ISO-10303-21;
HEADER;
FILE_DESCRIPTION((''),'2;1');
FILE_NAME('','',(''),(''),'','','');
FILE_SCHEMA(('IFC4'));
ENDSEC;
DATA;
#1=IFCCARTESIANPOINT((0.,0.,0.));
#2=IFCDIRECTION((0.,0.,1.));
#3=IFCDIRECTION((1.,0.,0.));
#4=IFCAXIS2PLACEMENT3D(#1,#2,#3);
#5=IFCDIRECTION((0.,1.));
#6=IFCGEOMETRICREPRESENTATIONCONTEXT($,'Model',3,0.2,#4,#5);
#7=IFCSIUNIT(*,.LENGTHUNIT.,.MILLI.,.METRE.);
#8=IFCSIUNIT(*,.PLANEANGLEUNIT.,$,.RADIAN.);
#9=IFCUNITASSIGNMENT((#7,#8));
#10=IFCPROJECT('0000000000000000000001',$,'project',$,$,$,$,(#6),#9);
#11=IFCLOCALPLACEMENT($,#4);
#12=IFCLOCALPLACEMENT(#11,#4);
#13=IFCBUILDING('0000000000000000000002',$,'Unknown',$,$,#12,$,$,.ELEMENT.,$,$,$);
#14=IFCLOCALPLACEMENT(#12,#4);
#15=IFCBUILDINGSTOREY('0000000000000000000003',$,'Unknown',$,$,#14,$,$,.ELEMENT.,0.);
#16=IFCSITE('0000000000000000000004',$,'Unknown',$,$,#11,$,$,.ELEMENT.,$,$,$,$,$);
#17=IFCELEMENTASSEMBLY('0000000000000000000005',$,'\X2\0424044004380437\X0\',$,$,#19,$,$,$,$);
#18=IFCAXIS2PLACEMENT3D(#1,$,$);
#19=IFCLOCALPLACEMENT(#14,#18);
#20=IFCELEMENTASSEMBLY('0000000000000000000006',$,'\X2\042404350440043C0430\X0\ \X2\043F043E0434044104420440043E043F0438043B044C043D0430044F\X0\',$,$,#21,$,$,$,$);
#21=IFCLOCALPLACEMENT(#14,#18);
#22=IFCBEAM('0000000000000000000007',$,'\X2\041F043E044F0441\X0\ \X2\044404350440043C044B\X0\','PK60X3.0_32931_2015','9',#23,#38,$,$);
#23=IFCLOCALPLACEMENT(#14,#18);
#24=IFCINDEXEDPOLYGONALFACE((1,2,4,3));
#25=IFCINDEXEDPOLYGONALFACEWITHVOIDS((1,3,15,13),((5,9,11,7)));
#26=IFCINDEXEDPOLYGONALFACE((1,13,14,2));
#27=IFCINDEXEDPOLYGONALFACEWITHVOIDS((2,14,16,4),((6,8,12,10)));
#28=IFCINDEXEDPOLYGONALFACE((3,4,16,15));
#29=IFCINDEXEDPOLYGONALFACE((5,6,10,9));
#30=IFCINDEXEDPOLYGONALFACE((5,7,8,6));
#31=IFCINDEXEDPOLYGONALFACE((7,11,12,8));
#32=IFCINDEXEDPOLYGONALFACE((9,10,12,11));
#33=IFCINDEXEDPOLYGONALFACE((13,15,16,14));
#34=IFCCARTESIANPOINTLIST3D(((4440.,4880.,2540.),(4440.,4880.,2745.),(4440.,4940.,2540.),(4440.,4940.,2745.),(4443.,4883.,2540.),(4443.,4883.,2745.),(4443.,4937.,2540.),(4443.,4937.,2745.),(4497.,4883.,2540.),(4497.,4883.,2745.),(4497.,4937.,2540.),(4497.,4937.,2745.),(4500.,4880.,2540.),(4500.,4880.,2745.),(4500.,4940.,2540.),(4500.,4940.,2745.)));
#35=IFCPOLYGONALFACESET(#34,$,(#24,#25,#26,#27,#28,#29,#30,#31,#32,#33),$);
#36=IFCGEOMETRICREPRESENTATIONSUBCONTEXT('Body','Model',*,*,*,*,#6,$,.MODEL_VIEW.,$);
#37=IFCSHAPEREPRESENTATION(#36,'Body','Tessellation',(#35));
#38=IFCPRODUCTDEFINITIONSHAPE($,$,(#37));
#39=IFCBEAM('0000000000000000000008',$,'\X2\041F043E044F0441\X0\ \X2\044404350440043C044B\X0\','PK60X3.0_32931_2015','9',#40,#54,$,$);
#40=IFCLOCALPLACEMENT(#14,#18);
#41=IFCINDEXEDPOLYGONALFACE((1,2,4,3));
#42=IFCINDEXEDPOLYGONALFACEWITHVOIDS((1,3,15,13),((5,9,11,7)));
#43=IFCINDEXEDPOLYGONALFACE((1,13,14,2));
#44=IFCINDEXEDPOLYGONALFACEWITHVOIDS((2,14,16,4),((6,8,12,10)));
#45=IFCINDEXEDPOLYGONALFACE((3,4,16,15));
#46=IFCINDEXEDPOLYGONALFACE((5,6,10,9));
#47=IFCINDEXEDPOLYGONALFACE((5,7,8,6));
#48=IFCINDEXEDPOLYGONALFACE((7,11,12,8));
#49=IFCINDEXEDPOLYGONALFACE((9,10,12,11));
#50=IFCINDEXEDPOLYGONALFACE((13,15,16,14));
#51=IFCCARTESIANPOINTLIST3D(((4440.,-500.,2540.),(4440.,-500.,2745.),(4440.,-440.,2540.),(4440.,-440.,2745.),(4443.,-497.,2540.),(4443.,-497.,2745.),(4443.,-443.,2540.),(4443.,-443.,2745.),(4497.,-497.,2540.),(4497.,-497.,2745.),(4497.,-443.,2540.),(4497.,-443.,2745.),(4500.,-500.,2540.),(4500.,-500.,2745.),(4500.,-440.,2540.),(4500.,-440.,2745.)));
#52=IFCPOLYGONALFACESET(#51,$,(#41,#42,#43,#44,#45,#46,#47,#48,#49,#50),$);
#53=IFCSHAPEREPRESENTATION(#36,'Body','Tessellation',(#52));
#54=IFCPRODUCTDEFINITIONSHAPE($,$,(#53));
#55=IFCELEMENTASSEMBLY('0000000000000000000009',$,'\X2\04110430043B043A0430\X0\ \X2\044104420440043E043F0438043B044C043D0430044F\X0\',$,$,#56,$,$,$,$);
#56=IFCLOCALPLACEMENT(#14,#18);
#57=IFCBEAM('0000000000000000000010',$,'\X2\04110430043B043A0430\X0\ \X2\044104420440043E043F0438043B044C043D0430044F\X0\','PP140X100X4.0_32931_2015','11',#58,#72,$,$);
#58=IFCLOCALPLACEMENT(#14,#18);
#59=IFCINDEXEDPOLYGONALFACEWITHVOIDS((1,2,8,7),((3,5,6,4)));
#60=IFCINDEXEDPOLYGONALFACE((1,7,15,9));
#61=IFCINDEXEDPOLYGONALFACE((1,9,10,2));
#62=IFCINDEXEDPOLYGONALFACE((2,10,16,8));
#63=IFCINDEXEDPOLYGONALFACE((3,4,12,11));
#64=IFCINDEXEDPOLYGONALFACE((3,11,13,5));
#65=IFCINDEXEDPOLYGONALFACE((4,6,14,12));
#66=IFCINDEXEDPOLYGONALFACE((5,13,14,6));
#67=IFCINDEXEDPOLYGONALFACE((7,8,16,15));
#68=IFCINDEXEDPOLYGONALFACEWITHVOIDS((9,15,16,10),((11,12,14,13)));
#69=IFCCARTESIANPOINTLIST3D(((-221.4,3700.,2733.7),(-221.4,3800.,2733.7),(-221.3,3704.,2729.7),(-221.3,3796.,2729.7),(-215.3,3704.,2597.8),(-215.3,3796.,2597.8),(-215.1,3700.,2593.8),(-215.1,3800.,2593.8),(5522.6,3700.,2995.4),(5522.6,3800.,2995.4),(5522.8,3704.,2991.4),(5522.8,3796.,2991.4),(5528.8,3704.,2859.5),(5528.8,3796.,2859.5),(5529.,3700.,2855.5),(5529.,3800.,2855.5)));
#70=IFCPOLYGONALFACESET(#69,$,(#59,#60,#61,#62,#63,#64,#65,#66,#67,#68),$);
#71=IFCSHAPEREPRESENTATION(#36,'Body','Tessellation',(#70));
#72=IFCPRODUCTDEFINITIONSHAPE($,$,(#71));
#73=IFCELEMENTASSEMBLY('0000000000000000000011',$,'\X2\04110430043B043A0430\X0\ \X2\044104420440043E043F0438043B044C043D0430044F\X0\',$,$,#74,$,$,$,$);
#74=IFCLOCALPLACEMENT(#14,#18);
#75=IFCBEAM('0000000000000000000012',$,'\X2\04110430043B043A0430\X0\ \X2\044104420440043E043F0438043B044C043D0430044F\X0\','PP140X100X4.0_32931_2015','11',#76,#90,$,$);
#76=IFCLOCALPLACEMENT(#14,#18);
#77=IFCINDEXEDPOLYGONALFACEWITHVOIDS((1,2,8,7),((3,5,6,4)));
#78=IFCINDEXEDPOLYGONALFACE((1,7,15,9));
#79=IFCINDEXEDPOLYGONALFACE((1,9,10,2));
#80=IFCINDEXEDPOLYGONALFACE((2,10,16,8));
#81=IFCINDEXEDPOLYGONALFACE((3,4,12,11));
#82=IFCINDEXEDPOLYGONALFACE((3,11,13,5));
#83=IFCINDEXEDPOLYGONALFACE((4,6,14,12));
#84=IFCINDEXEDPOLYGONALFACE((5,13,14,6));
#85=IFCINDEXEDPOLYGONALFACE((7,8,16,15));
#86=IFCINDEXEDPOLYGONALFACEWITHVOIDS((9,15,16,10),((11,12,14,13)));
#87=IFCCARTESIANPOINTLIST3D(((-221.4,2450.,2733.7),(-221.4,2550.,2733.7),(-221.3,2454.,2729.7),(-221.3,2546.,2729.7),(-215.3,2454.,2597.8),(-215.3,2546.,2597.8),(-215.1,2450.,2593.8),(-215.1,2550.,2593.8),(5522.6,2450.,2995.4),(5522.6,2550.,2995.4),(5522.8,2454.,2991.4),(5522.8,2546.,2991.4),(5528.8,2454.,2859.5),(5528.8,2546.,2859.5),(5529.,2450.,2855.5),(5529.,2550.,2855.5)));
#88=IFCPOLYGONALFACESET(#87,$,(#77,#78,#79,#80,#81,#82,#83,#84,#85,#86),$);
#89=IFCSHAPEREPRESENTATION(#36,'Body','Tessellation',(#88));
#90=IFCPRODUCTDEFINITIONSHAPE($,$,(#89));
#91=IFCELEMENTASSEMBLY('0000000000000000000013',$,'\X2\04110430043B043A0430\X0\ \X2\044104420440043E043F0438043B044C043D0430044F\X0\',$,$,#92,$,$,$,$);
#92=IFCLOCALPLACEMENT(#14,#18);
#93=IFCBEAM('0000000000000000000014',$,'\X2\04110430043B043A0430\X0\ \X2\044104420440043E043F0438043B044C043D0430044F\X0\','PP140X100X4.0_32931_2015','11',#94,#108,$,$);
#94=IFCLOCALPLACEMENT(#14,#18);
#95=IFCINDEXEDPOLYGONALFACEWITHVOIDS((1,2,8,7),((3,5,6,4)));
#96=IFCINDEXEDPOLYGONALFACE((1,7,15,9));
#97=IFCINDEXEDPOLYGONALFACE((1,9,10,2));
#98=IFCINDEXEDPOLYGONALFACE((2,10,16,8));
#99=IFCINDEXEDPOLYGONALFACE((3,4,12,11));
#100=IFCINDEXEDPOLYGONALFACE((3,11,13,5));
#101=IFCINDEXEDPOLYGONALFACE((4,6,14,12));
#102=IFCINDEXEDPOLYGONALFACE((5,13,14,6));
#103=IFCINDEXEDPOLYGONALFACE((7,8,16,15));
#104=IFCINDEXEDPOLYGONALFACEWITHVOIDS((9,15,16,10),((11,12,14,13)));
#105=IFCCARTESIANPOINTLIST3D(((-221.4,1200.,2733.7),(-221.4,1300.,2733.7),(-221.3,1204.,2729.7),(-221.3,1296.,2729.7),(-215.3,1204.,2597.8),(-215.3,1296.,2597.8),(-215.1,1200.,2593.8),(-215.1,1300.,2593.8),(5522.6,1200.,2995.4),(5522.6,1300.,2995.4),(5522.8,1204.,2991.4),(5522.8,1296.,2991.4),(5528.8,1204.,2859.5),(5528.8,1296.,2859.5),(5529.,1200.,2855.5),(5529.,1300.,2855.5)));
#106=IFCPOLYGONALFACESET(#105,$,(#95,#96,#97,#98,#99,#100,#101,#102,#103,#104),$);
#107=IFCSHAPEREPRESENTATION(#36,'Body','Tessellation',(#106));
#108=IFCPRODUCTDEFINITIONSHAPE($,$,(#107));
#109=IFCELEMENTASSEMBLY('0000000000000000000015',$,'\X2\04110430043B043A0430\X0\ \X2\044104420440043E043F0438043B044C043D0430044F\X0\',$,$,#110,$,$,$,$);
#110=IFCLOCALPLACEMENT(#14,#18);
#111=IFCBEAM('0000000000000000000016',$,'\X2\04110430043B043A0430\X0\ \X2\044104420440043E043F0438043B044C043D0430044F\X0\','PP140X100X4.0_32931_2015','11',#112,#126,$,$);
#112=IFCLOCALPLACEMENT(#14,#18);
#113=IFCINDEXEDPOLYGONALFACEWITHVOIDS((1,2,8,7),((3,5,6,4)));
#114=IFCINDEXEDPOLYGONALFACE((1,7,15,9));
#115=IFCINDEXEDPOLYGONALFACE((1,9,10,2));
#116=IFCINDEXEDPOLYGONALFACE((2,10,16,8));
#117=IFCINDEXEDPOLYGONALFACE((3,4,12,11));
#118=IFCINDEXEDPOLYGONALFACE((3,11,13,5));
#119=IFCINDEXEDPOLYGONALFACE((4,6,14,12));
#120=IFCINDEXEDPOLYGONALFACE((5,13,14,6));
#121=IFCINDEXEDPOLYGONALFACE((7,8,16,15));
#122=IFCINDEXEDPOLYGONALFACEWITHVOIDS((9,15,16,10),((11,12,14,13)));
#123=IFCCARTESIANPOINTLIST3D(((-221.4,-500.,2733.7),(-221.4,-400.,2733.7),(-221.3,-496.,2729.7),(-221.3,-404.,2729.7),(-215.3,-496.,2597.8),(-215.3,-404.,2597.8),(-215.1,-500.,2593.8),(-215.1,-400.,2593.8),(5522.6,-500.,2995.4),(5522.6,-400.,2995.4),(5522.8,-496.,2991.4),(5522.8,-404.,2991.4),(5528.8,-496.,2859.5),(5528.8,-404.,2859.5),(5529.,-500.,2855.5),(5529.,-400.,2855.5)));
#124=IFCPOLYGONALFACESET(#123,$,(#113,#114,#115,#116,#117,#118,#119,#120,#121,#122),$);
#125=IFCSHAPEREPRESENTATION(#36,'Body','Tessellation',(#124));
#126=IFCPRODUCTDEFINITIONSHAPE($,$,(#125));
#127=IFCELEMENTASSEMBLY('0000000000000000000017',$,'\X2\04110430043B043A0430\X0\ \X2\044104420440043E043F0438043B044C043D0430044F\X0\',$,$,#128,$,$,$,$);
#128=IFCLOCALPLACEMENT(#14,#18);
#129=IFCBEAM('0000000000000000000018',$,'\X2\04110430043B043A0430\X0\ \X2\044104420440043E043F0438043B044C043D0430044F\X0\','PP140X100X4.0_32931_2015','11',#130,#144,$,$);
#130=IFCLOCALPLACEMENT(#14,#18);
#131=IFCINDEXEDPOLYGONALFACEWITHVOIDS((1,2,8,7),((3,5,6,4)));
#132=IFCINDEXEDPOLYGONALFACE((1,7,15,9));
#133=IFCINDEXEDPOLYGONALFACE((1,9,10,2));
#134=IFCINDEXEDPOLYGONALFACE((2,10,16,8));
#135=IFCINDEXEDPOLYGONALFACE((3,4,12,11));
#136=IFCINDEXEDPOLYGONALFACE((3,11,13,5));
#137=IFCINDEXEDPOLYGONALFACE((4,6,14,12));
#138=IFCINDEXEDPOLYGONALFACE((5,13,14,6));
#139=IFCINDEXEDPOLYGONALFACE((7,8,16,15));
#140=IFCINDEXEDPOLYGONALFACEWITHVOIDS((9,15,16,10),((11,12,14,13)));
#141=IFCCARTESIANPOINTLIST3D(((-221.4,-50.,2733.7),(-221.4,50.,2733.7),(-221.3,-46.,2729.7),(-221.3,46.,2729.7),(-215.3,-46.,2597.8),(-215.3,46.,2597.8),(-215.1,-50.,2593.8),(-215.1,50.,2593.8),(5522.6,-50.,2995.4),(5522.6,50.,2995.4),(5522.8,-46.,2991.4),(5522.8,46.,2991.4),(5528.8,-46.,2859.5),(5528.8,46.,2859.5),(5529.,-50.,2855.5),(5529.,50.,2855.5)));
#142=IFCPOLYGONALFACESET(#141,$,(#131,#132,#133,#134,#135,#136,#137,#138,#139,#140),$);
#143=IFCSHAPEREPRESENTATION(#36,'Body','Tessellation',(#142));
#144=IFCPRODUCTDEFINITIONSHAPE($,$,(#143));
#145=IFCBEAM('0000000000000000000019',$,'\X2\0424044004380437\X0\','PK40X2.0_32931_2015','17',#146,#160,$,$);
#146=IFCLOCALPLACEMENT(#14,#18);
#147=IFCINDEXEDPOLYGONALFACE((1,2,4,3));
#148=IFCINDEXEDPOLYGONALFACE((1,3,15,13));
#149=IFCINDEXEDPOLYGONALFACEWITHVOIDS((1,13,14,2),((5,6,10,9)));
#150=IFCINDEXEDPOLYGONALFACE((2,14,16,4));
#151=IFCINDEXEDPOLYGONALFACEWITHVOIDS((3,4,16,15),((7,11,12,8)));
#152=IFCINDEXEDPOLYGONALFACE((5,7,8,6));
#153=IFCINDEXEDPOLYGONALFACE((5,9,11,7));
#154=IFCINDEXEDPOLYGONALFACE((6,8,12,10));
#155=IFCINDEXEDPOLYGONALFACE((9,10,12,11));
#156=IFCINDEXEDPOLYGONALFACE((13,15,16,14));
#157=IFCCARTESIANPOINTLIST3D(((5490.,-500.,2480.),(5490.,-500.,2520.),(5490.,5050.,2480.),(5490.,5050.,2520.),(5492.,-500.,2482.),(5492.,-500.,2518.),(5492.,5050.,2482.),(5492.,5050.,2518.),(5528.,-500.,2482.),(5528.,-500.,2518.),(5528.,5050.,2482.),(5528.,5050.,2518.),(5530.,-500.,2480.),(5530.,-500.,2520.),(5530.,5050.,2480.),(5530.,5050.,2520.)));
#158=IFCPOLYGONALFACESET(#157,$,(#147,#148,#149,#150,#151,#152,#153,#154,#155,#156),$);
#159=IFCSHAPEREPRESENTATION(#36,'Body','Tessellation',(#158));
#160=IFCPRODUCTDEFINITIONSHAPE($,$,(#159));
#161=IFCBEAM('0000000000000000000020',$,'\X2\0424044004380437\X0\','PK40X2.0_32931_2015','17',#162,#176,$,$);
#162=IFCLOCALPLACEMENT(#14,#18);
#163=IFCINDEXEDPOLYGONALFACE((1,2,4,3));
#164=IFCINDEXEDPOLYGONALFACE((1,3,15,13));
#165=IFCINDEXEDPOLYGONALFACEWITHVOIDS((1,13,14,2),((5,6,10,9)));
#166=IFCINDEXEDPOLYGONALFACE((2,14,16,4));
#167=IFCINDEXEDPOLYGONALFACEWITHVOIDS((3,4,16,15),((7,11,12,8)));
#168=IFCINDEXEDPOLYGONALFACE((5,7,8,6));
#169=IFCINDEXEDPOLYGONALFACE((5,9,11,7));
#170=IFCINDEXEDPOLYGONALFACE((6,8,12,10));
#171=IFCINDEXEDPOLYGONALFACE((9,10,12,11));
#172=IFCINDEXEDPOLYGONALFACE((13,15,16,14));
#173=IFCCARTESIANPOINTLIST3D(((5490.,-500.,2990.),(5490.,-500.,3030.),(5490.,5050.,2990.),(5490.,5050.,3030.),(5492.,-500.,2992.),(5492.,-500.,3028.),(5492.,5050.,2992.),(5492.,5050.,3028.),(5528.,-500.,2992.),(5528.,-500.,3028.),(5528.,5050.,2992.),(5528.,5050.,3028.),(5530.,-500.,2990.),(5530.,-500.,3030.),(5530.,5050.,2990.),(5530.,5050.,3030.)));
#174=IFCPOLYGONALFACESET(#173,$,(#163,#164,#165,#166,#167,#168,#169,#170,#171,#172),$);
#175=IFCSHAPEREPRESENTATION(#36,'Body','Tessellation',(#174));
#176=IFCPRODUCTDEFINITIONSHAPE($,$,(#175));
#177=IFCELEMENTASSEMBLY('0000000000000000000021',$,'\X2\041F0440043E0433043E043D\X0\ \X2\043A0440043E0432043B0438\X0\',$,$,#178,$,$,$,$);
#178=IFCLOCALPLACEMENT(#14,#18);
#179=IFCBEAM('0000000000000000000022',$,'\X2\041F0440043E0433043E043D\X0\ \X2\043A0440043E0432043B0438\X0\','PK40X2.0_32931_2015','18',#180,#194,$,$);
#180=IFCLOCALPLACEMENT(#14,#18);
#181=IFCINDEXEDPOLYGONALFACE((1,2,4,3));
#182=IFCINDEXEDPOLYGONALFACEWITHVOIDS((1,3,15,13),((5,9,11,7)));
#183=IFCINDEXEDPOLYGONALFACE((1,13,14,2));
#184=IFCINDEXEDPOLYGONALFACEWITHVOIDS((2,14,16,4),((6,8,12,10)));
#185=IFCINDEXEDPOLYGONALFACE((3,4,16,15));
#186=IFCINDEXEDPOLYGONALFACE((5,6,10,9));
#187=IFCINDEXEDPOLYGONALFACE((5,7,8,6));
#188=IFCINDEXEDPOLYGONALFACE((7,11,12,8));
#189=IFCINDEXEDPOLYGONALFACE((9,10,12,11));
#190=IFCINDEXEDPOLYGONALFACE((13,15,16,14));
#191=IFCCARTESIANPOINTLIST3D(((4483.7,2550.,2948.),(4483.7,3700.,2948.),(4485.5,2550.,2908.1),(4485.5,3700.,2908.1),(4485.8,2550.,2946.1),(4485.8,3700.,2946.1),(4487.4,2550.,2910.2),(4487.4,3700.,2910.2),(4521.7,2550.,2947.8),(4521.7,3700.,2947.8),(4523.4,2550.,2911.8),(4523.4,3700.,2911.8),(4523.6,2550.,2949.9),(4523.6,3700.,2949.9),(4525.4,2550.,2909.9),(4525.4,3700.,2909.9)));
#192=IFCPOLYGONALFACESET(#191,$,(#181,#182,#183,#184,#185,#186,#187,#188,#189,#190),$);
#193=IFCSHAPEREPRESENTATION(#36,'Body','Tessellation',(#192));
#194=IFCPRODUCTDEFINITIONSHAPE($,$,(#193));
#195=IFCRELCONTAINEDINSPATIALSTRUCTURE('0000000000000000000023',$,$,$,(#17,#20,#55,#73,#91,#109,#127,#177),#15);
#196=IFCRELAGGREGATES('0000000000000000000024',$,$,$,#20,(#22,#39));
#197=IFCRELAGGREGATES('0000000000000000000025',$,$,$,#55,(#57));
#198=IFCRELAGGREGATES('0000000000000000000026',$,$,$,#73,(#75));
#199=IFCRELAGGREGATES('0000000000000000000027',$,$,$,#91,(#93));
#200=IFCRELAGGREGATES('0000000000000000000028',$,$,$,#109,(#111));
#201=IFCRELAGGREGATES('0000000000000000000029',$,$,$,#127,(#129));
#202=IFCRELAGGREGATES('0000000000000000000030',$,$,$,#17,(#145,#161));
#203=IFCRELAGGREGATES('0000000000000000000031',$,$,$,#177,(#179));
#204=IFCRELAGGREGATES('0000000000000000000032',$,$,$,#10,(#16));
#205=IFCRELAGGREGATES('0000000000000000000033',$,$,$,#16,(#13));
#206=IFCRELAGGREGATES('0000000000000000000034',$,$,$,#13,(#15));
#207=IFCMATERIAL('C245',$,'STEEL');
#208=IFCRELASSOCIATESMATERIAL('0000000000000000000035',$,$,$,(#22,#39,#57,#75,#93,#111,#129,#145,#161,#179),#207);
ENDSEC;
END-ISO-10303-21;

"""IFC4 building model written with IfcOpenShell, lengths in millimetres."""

from ifc_helpers import new_model, si_unit, direction, frame, origin_with_axes, place, context, subcontext, project, spatial, line, indexed_curve, outline, extrude, material, element, aggregate, save


model = new_model("IFC4")

# Units and contexts
model_context = context("Model", 3, precision=0.2, world=origin_with_axes(), true_north=direction((0.0, 1.0)))
body_context = subcontext(model_context, "Body", "Model", "MODEL_VIEW")
ifc_project = project(units=[si_unit("LENGTHUNIT", "METRE", prefix="MILLI"), si_unit("PLANEANGLEUNIT", "RADIAN")], contexts=[model_context])

# Site, building, storey
site_placement = place(None, origin_with_axes())
site = spatial("IfcSite", under=ifc_project, at=site_placement, Name="Unknown", CompositionType="ELEMENT")
building_placement = place(site_placement, origin_with_axes())
building = spatial("IfcBuilding", under=site, at=building_placement, Name="Unknown", CompositionType="ELEMENT")
storey_placement = place(building_placement, origin_with_axes())
storey = spatial("IfcBuildingStorey", under=building, at=storey_placement, Name="Unknown", CompositionType="ELEMENT", Elevation=0.0)

# Shared definitions
ifc_material = material(Name="C245", Category="STEEL")

# Element assembly
assembly_1_placement = place(storey_placement, frame((5510.0, -500.0, 3010.0), z_axis=(1.0, 0.0, 0.0), x_axis=(0.0, 1.0, 0.0)))
assembly_1 = element("IfcElementAssembly", 1, at=assembly_1_placement, inside=storey, Name="Фриз")

# Element assembly, beams
assembly_2_placement = place(storey_placement, frame((4470.0, 4940.0, 2775.0), z_axis=(-1.0, 0.0, 0.0), x_axis=(0.0, -1.0, 0.0)))
assembly_2 = element("IfcElementAssembly", 2, at=assembly_2_placement, inside=storey, Name="Ферма подстропильная")
beam_1_placement = place(assembly_2_placement, frame((30.0, -30.0, 0.0), z_axis=(1.0, 0.0, 0.0), x_axis=(0.0, -1.0, 0.0)))
beam_1 = element("IfcBeam", 3, at=beam_1_placement, material=ifc_material, Name="Пояс фермы", Description="PK60X3.0_32931_2015", ObjectType="9", context=body_context, shape_type="SolidModel", body=[
    extrude(outline(indexed_curve([(-30.0, -30.0), (30.0, -30.0), (30.0, 30.0), (-30.0, 30.0)], segments=[line(1, 2, 3, 4, 1)]), holes=[indexed_curve([(-27.0, -27.0), (-27.0, 27.0), (27.0, 27.0), (27.0, -27.0)], segments=[line(1, 2, 3, 4, 1)])]), frame((0.0, 0.0, 0.0), z_axis=(-1.0, 0.0, 0.0), x_axis=(0.0, 0.0, 1.0)), (0.0, 0.0, -1.0), 205.0),
])
beam_2_placement = place(assembly_2_placement, frame((5410.0, -30.0, 0.0), z_axis=(1.0, 0.0, 0.0), x_axis=(0.0, -1.0, 0.0)))
beam_2 = element("IfcBeam", 4, at=beam_2_placement, material=ifc_material, Name="Пояс фермы", Description="PK60X3.0_32931_2015", ObjectType="9", context=body_context, shape_type="SolidModel", body=[
    extrude(outline(indexed_curve([(-30.0, -30.0), (30.0, -30.0), (30.0, 30.0), (-30.0, 30.0)], segments=[line(1, 2, 3, 4, 1)]), holes=[indexed_curve([(-27.0, -27.0), (-27.0, 27.0), (27.0, 27.0), (27.0, -27.0)], segments=[line(1, 2, 3, 4, 1)])]), frame((0.0, 0.0, 0.0), z_axis=(-1.0, 0.0, 0.0), x_axis=(0.0, 0.0, 1.0)), (0.0, 0.0, -1.0), 205.0),
])
aggregate(assembly_2, [beam_1, beam_2])

# Element assemblies, beams
assembly_3_placement = place(storey_placement, frame((5525.8, 3750.0, 2925.4), z_axis=(0.0, 1.0, 0.0), x_axis=(-0.998964, 0.0, -0.045508)))
assembly_3 = element("IfcElementAssembly", 5, at=assembly_3_placement, inside=storey, Name="Балка стропильная")
beam_3_placement = place(assembly_3_placement, origin_with_axes())
beam_3 = element("IfcBeam", 6, at=beam_3_placement, material=ifc_material, Name="Балка стропильная", Description="PP140X100X4.0_32931_2015", ObjectType="11", context=body_context, shape_type="SolidModel", body=[
    extrude(outline(indexed_curve([(-50.0, -70.0), (50.0, -70.0), (50.0, 70.0), (-50.0, 70.0)], segments=[line(1, 2, 3, 4, 1)]), holes=[indexed_curve([(-46.0, -66.0), (-46.0, 66.0), (46.0, 66.0), (46.0, -66.0)], segments=[line(1, 2, 3, 4, 1)])]), frame((0.0, 0.0, 0.0), z_axis=(-1.0, 0.0, 0.0), x_axis=(0.0, 0.0, 1.0)), (0.0, 0.0, -1.0), 5750.0),
])
aggregate(assembly_3, [beam_3])
assembly_4_placement = place(storey_placement, frame((5525.8, 2500.0, 2925.4), z_axis=(0.0, 1.0, 0.0), x_axis=(-0.998964, 0.0, -0.045508)))
assembly_4 = element("IfcElementAssembly", 7, at=assembly_4_placement, inside=storey, Name="Балка стропильная")
beam_4_placement = place(assembly_4_placement, origin_with_axes())
beam_4 = element("IfcBeam", 8, at=beam_4_placement, material=ifc_material, Name="Балка стропильная", Description="PP140X100X4.0_32931_2015", ObjectType="11", context=body_context, shape_type="SolidModel", body=[
    extrude(outline(indexed_curve([(-50.0, -70.0), (50.0, -70.0), (50.0, 70.0), (-50.0, 70.0)], segments=[line(1, 2, 3, 4, 1)]), holes=[indexed_curve([(-46.0, -66.0), (-46.0, 66.0), (46.0, 66.0), (46.0, -66.0)], segments=[line(1, 2, 3, 4, 1)])]), frame((0.0, 0.0, 0.0), z_axis=(-1.0, 0.0, 0.0), x_axis=(0.0, 0.0, 1.0)), (0.0, 0.0, -1.0), 5750.0),
])
aggregate(assembly_4, [beam_4])
assembly_5_placement = place(storey_placement, frame((5525.8, 1250.0, 2925.4), z_axis=(0.0, 1.0, 0.0), x_axis=(-0.998964, 0.0, -0.045508)))
assembly_5 = element("IfcElementAssembly", 9, at=assembly_5_placement, inside=storey, Name="Балка стропильная")
beam_5_placement = place(assembly_5_placement, origin_with_axes())
beam_5 = element("IfcBeam", 10, at=beam_5_placement, material=ifc_material, Name="Балка стропильная", Description="PP140X100X4.0_32931_2015", ObjectType="11", context=body_context, shape_type="SolidModel", body=[
    extrude(outline(indexed_curve([(-50.0, -70.0), (50.0, -70.0), (50.0, 70.0), (-50.0, 70.0)], segments=[line(1, 2, 3, 4, 1)]), holes=[indexed_curve([(-46.0, -66.0), (-46.0, 66.0), (46.0, 66.0), (46.0, -66.0)], segments=[line(1, 2, 3, 4, 1)])]), frame((0.0, 0.0, 0.0), z_axis=(-1.0, 0.0, 0.0), x_axis=(0.0, 0.0, 1.0)), (0.0, 0.0, -1.0), 5750.0),
])
aggregate(assembly_5, [beam_5])
assembly_6_placement = place(storey_placement, frame((5525.8, -450.0, 2925.4), z_axis=(0.0, 1.0, 0.0), x_axis=(-0.998964, 0.0, -0.045508)))
assembly_6 = element("IfcElementAssembly", 11, at=assembly_6_placement, inside=storey, Name="Балка стропильная")
beam_6_placement = place(assembly_6_placement, origin_with_axes())
beam_6 = element("IfcBeam", 12, at=beam_6_placement, material=ifc_material, Name="Балка стропильная", Description="PP140X100X4.0_32931_2015", ObjectType="11", context=body_context, shape_type="SolidModel", body=[
    extrude(outline(indexed_curve([(-50.0, -70.0), (50.0, -70.0), (50.0, 70.0), (-50.0, 70.0)], segments=[line(1, 2, 3, 4, 1)]), holes=[indexed_curve([(-46.0, -66.0), (-46.0, 66.0), (46.0, 66.0), (46.0, -66.0)], segments=[line(1, 2, 3, 4, 1)])]), frame((0.0, 0.0, 0.0), z_axis=(-1.0, 0.0, 0.0), x_axis=(0.0, 0.0, 1.0)), (0.0, 0.0, -1.0), 5750.0),
])
aggregate(assembly_6, [beam_6])
assembly_7_placement = place(storey_placement, frame((5525.8, 0.0, 2925.4), z_axis=(0.0, 1.0, 0.0), x_axis=(-0.998964, 0.0, -0.045508)))
assembly_7 = element("IfcElementAssembly", 13, at=assembly_7_placement, inside=storey, Name="Балка стропильная")
beam_7_placement = place(assembly_7_placement, origin_with_axes())
beam_7 = element("IfcBeam", 14, at=beam_7_placement, material=ifc_material, Name="Балка стропильная", Description="PP140X100X4.0_32931_2015", ObjectType="11", context=body_context, shape_type="SolidModel", body=[
    extrude(outline(indexed_curve([(-50.0, -70.0), (50.0, -70.0), (50.0, 70.0), (-50.0, 70.0)], segments=[line(1, 2, 3, 4, 1)]), holes=[indexed_curve([(-46.0, -66.0), (-46.0, 66.0), (46.0, 66.0), (46.0, -66.0)], segments=[line(1, 2, 3, 4, 1)])]), frame((0.0, 0.0, 0.0), z_axis=(-1.0, 0.0, 0.0), x_axis=(0.0, 0.0, 1.0)), (0.0, 0.0, -1.0), 5750.0),
])
aggregate(assembly_7, [beam_7])

# Beams
beam_8_placement = place(assembly_1_placement, frame((0.0, -510.0, 0.0), z_axis=(0.0, 0.0, 1.0), x_axis=(1.0, 0.0, 0.0)))
beam_8 = element("IfcBeam", 15, at=beam_8_placement, material=ifc_material, Name="Фриз", Description="PK40X2.0_32931_2015", ObjectType="17", context=body_context, shape_type="SolidModel", body=[
    extrude(outline(indexed_curve([(-20.0, -20.0), (20.0, -20.0), (20.0, 20.0), (-20.0, 20.0)], segments=[line(1, 2, 3, 4, 1)]), holes=[indexed_curve([(-18.0, -18.0), (-18.0, 18.0), (18.0, 18.0), (18.0, -18.0)], segments=[line(1, 2, 3, 4, 1)])]), frame((0.0, 0.0, 0.0), z_axis=(-1.0, 0.0, 0.0), x_axis=(0.0, 0.0, 1.0)), (0.0, 0.0, -1.0), 5550.0),
])
beam_9_placement = place(assembly_1_placement, origin_with_axes())
beam_9 = element("IfcBeam", 16, at=beam_9_placement, material=ifc_material, Name="Фриз", Description="PK40X2.0_32931_2015", ObjectType="17", context=body_context, shape_type="SolidModel", body=[
    extrude(outline(indexed_curve([(-20.0, -20.0), (20.0, -20.0), (20.0, 20.0), (-20.0, 20.0)], segments=[line(1, 2, 3, 4, 1)]), holes=[indexed_curve([(-18.0, -18.0), (-18.0, 18.0), (18.0, 18.0), (18.0, -18.0)], segments=[line(1, 2, 3, 4, 1)])]), frame((0.0, 0.0, 0.0), z_axis=(-1.0, 0.0, 0.0), x_axis=(0.0, 0.0, 1.0)), (0.0, 0.0, -1.0), 5550.0),
])
aggregate(assembly_1, [beam_8, beam_9])

# Element assembly, beam
assembly_8_placement = place(storey_placement, frame((4504.6, 3700.0, 2929.0), z_axis=(-0.998964, 0.0, -0.045508), x_axis=(0.0, -1.0, 0.0)))
assembly_8 = element("IfcElementAssembly", 17, at=assembly_8_placement, inside=storey, Name="Прогон кровли")
beam_10_placement = place(assembly_8_placement, origin_with_axes())
beam_10 = element("IfcBeam", 18, at=beam_10_placement, material=ifc_material, Name="Прогон кровли", Description="PK40X2.0_32931_2015", ObjectType="18", context=body_context, shape_type="SolidModel", body=[
    extrude(outline(indexed_curve([(-20.0, -20.0), (20.0, -20.0), (20.0, 20.0), (-20.0, 20.0)], segments=[line(1, 2, 3, 4, 1)]), holes=[indexed_curve([(-18.0, -18.0), (-18.0, 18.0), (18.0, 18.0), (18.0, -18.0)], segments=[line(1, 2, 3, 4, 1)])]), frame((0.0, 0.0, 0.0), z_axis=(-1.0, 0.0, 0.0), x_axis=(0.0, 0.0, 1.0)), (0.0, 0.0, -1.0), 1150.0),
])
aggregate(assembly_8, [beam_10])

save(model, "model.ifc")
